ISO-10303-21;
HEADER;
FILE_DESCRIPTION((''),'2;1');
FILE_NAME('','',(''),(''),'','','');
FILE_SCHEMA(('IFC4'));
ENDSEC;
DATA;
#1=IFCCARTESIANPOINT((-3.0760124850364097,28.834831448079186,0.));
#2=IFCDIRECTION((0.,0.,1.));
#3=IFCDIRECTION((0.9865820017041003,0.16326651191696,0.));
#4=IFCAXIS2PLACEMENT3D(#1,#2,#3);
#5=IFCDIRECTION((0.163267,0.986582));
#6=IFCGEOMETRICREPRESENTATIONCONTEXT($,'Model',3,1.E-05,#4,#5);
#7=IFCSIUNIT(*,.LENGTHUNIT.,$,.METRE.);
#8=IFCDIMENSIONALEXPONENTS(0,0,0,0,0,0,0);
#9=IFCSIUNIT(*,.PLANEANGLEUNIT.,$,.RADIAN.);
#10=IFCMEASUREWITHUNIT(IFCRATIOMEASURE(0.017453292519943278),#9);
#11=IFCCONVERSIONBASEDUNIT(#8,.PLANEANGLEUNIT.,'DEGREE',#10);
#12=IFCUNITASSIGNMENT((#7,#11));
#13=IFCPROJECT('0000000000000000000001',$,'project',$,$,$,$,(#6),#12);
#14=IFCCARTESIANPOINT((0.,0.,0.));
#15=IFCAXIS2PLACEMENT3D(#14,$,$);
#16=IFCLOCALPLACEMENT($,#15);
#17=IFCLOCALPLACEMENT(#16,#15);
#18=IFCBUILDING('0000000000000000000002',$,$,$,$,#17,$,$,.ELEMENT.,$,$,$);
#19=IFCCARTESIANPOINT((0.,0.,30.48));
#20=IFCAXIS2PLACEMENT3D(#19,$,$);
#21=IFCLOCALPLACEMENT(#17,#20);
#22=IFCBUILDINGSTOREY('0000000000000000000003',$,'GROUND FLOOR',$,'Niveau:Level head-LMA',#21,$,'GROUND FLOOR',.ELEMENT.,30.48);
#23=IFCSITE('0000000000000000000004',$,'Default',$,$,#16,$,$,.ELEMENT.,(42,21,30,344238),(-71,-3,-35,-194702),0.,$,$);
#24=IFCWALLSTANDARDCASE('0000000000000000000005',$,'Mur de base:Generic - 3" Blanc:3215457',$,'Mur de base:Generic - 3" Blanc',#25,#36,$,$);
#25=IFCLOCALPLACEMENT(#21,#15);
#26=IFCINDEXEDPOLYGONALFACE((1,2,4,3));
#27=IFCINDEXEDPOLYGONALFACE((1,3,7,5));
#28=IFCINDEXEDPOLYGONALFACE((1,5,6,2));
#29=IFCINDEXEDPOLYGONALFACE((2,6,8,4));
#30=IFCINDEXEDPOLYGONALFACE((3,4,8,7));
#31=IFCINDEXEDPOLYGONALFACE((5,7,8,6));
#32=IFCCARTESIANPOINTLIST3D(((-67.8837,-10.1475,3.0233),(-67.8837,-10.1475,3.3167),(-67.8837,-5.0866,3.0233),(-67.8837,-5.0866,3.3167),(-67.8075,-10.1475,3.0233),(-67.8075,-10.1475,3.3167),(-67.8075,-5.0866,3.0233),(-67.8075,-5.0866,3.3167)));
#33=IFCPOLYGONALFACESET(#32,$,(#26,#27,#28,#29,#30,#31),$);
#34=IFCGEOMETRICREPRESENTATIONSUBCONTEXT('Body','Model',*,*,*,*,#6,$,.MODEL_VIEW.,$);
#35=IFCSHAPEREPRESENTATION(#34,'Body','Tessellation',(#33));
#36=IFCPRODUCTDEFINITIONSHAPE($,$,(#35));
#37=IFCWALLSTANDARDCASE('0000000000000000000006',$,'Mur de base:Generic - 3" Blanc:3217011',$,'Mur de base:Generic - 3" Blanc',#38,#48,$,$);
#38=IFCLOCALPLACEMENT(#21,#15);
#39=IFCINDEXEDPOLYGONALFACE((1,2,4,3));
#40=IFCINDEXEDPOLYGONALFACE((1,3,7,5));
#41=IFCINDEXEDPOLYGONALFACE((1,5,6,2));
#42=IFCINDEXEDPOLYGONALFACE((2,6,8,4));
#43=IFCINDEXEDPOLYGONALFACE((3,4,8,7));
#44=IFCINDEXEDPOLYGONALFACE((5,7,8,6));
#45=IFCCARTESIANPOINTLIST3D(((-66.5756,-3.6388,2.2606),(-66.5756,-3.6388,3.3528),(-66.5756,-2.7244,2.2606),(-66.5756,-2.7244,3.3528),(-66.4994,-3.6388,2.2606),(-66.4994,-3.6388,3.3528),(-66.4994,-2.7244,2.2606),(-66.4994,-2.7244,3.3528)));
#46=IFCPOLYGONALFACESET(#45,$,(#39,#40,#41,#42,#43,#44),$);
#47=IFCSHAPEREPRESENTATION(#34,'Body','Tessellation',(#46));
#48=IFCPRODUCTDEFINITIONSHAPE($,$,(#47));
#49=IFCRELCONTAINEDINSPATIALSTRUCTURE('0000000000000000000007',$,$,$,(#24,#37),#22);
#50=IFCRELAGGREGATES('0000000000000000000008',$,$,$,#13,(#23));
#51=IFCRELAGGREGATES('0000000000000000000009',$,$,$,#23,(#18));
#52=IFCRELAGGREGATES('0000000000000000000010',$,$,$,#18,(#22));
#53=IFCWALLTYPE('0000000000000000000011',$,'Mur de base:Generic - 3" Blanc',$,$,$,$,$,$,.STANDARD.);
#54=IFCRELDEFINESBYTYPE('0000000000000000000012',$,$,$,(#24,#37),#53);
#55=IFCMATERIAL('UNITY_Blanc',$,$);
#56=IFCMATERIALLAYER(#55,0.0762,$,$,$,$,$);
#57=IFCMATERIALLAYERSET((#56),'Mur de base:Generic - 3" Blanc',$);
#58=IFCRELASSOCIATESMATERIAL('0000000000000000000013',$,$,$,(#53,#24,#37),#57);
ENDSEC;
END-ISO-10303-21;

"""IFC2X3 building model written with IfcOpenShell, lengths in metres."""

from ifc_helpers import new_model, entity, si_unit, converted_unit, direction, frame, frame_2d, origin, place, context, subcontext, project, spatial, rectangle, extrude, material, layer, layer_set, layer_usage, type_object, element, save


model = new_model("IFC2X3")

# Units and contexts
model_context = context("Model", 3, precision=1e-05, world=frame((-3.0760124850364097, 28.834831448079186, 0.0), z_axis=(0.0, 0.0, 1.0), x_axis=(0.9865820017041003, 0.16326651191696, 0.0)), true_north=direction((0.163267, 0.986582)))
body_context = subcontext(model_context, "Body", "Model", "MODEL_VIEW")
ifc_project = project(units=[si_unit("LENGTHUNIT", "METRE"), converted_unit("PLANEANGLEUNIT", "DEGREE", entity("IfcRatioMeasure", 0.017453292519943278), si_unit("PLANEANGLEUNIT", "RADIAN"), dimensions=[0, 0, 0, 0, 0, 0, 0])], contexts=[model_context])

# Site, building, storey
site_placement = place(None, origin())
site = spatial("IfcSite", under=ifc_project, at=site_placement, Name="Default", CompositionType="ELEMENT", RefLatitude=(42, 21, 30, 344238), RefLongitude=(-71, -3, -35, -194702), RefElevation=0.0)
building_placement = place(site_placement, origin())
building = spatial("IfcBuilding", under=site, at=building_placement, CompositionType="ELEMENT")
storey_placement = place(building_placement, frame((0.0, 0.0, 30.48)))
storey = spatial("IfcBuildingStorey", under=building, at=storey_placement, Name="GROUND FLOOR", ObjectType="Niveau:Level head-LMA", LongName="GROUND FLOOR", CompositionType="ELEMENT", Elevation=30.48)

# Shared definitions
ifc_material_1 = material(Name="UNITY_Blanc")
ifc_layer_1 = layer(ifc_material_1, 0.0762)
ifc_layer_set_1 = layer_set([ifc_layer_1], Name="Mur de base:Generic - 3\" Blanc")
wall_type_1 = type_object("IfcWallType", Name="Mur de base:Generic - 3\" Blanc", PredefinedType="STANDARD", material=ifc_layer_set_1)

# Walls
ifc_layer_usage_1 = layer_usage(ifc_layer_set_1, "AXIS2", "POSITIVE", -0.0381)
wall_1_placement = place(storey_placement, frame((-67.8456, -5.0866, 3.0233), z_axis=(0.0, 0.0, 1.0), x_axis=(0.0, -1.0, 0.0)))
element("IfcWallStandardCase", 1, at=wall_1_placement, inside=storey, type_object=wall_type_1, material=ifc_layer_usage_1, Name="Mur de base:Generic - 3\" Blanc:3215457", ObjectType="Mur de base:Generic - 3\" Blanc", context=body_context, shape_type="SweptSolid", body=[
    extrude(rectangle(XDim=5.061, YDim=0.0762, at=frame_2d((2.5305, 0.0), x_axis=(-1.0, 0.0))), origin(), (0.0, 0.0, 1.0), 0.2934),
])
ifc_layer_usage_2 = layer_usage(ifc_layer_set_1, "AXIS2", "POSITIVE", -0.0381)
wall_2_placement = place(storey_placement, frame((-66.5375, -3.6388, 2.2606), z_axis=(0.0, 0.0, 1.0), x_axis=(0.0, 1.0, 0.0)))
element("IfcWallStandardCase", 2, at=wall_2_placement, inside=storey, type_object=wall_type_1, material=ifc_layer_usage_2, Name="Mur de base:Generic - 3\" Blanc:3217011", ObjectType="Mur de base:Generic - 3\" Blanc", context=body_context, shape_type="SweptSolid", body=[
    extrude(rectangle(XDim=0.9144, YDim=0.0762, at=frame_2d((0.4572, 0.0), x_axis=(-1.0, 0.0))), origin(), (0.0, 0.0, 1.0), 1.0922),
])

save(model, "model.ifc")
